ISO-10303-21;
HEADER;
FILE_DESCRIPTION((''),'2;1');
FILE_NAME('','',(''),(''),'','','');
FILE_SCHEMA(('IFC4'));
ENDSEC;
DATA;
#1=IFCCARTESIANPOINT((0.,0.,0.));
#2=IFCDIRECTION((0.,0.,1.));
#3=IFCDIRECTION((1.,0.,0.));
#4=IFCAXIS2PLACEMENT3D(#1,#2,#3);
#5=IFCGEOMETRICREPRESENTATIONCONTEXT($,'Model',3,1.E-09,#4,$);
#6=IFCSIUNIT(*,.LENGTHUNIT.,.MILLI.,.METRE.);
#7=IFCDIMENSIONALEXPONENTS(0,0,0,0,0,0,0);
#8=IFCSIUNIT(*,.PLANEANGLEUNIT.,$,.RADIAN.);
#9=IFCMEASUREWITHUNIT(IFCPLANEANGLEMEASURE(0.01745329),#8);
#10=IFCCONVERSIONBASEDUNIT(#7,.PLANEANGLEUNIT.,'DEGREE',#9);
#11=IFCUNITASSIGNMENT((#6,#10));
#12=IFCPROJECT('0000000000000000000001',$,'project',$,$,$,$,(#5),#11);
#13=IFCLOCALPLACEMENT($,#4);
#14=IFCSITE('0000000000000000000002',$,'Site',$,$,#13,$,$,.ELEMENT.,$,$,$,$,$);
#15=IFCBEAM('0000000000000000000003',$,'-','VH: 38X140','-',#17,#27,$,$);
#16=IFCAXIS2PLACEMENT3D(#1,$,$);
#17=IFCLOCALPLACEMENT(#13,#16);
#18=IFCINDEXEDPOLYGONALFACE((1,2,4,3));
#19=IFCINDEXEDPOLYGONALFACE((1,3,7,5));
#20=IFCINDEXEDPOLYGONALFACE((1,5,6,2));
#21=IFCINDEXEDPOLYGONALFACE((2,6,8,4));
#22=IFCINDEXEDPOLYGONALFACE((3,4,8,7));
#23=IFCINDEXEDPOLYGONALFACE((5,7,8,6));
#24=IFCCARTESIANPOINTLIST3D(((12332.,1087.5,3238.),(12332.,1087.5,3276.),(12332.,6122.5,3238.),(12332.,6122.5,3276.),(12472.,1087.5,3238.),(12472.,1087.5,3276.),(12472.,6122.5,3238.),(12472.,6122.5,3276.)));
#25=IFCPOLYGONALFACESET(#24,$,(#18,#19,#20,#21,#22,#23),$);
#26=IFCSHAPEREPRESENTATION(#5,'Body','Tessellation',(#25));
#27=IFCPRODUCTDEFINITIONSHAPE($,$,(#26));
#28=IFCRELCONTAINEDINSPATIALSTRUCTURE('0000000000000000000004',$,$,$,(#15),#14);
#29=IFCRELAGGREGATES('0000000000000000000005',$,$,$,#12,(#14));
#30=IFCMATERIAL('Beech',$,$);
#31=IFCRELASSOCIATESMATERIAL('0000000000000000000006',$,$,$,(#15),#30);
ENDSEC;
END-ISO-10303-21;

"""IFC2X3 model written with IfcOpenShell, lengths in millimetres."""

from ifc_helpers import new_model, entity, si_unit, converted_unit, frame, origin, origin_with_axes, origin_2d, place, context, project, spatial, rectangle, extrude, material, element, save


model = new_model("IFC2X3")

# Units and contexts
model_context = context("Model", 3, precision=1e-09, world=origin_with_axes())
ifc_project = project(units=[si_unit("LENGTHUNIT", "METRE", prefix="MILLI"), converted_unit("PLANEANGLEUNIT", "DEGREE", entity("IfcPlaneAngleMeasure", 0.01745329), si_unit("PLANEANGLEUNIT", "RADIAN"), dimensions=[0, 0, 0, 0, 0, 0, 0])], contexts=[model_context])

# Site
site_placement = place(None, origin_with_axes())
site = spatial("IfcSite", under=ifc_project, at=site_placement, Name="Site", CompositionType="ELEMENT")

# Shared definitions
ifc_material = material(Name="Beech")

# Beam
beam_1_placement = place(None, frame((12402.0, 6122.5, 3257.0), z_axis=(0.000003, -1.0, 0.0), x_axis=(0.0, 0.0, -1.0)))
element("IfcBeam", 1, at=beam_1_placement, inside=site, material=ifc_material, Name="-", Description="VH: 38X140", ObjectType="-", context=model_context, shape_type="SweptSolid", body=[
    extrude(rectangle(XDim=38.0, YDim=140.0, at=origin_2d()), origin(), (0.0, 0.0, 1.0), 5035.0),
])

save(model, "model.ifc")
